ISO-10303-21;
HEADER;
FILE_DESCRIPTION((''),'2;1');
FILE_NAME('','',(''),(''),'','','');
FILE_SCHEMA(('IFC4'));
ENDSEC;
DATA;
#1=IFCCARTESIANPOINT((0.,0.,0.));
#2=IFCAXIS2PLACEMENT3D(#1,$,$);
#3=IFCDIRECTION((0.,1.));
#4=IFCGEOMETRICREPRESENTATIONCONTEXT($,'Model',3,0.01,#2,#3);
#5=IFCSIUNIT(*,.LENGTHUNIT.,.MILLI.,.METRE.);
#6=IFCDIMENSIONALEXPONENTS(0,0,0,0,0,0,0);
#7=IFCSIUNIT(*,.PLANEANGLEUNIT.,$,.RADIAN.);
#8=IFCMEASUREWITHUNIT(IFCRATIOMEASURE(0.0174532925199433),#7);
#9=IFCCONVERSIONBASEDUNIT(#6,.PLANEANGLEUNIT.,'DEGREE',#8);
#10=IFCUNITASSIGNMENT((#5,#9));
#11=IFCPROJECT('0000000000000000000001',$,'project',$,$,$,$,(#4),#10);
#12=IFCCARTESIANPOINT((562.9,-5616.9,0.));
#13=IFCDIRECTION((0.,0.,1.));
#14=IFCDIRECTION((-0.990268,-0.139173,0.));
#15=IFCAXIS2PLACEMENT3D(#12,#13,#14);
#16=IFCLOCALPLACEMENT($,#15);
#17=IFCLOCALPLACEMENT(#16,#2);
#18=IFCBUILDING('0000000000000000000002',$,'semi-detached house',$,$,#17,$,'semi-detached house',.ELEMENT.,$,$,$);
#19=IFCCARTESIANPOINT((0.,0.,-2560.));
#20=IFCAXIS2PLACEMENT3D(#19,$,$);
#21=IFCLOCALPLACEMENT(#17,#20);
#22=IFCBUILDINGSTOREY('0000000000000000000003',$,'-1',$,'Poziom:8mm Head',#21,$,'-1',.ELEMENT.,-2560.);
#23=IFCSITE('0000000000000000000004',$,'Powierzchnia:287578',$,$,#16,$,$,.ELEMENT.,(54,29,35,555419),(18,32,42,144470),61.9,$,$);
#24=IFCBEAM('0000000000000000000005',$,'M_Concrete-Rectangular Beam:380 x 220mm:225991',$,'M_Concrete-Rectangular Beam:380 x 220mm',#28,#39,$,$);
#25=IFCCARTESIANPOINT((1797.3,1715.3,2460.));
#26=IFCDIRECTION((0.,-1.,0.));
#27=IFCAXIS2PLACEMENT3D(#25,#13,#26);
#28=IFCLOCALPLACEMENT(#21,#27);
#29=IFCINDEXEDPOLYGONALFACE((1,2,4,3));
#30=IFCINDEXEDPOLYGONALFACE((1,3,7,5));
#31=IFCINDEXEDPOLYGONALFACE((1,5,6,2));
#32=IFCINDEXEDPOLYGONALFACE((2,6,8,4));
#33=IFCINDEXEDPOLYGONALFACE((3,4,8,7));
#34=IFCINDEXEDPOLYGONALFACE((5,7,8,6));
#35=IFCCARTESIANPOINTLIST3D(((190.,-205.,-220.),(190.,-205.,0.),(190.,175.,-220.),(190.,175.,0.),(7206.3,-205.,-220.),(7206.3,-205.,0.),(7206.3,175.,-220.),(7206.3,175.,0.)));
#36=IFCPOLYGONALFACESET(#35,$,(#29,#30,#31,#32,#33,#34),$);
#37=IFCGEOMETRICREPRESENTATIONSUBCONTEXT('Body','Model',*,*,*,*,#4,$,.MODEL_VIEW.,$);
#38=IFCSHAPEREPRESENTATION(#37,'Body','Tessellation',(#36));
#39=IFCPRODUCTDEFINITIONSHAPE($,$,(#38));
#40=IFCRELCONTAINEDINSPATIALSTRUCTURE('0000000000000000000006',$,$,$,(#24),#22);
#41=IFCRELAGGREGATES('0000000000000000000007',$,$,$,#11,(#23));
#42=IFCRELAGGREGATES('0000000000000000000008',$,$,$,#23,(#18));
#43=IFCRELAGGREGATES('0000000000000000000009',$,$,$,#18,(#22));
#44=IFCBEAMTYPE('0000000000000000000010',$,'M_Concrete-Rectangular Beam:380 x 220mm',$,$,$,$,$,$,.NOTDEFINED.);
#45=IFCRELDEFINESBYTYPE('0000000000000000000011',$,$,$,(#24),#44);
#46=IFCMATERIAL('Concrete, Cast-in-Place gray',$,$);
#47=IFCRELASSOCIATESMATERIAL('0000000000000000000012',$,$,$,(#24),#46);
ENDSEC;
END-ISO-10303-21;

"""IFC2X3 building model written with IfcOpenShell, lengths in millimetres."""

from ifc_helpers import new_model, entity, si_unit, converted_unit, direction, frame, frame_2d, origin, place, context, subcontext, project, spatial, rectangle, extrude, material, type_object, element, save


model = new_model("IFC2X3")

# Units and contexts
model_context = context("Model", 3, precision=0.01, world=origin(), true_north=direction((0.0, 1.0)))
body_context = subcontext(model_context, "Body", "Model", "MODEL_VIEW")
ifc_project = project(units=[si_unit("LENGTHUNIT", "METRE", prefix="MILLI"), converted_unit("PLANEANGLEUNIT", "DEGREE", entity("IfcRatioMeasure", 0.0174532925199433), si_unit("PLANEANGLEUNIT", "RADIAN"), dimensions=[0, 0, 0, 0, 0, 0, 0])], contexts=[model_context])

# Site, building, storey
site_placement = place(None, frame((562.9, -5616.9, 0.0), z_axis=(0.0, 0.0, 1.0), x_axis=(-0.990268, -0.139173, 0.0)))
site = spatial("IfcSite", under=ifc_project, at=site_placement, Name="Powierzchnia:287578", CompositionType="ELEMENT", RefLatitude=(54, 29, 35, 555419), RefLongitude=(18, 32, 42, 144470), RefElevation=61.9)
building_placement = place(site_placement, origin())
building = spatial("IfcBuilding", under=site, at=building_placement, Name="semi-detached house", LongName="semi-detached house", CompositionType="ELEMENT")
storey_placement = place(building_placement, frame((0.0, 0.0, -2560.0)))
storey = spatial("IfcBuildingStorey", under=building, at=storey_placement, Name="-1", ObjectType="Poziom:8mm Head", LongName="-1", CompositionType="ELEMENT", Elevation=-2560.0)

# Beam
ifc_material_1 = material(Name="Concrete, Cast-in-Place gray")
beam_type = type_object("IfcBeamType", Name="M_Concrete-Rectangular Beam:380 x 220mm", PredefinedType="NOTDEFINED")
beam_placement = place(storey_placement, frame((1797.3, 1715.3, 2460.0), z_axis=(0.0, 0.0, 1.0), x_axis=(0.0, -1.0, 0.0)))
element("IfcBeam", 1, at=beam_placement, inside=storey, type_object=beam_type, material=ifc_material_1, Name="M_Concrete-Rectangular Beam:380 x 220mm:225991", ObjectType="M_Concrete-Rectangular Beam:380 x 220mm", context=body_context, shape_type="SweptSolid", body=[
    extrude(rectangle(XDim=220.0, YDim=380.0, at=frame_2d((0.0, 0.0), x_axis=(1.0, 0.0))), frame((190.0, -15.0, -110.0), z_axis=(1.0, 0.0, 0.0), x_axis=(0.0, 0.0, -1.0)), (0.0, 0.0, 1.0), 7016.3),
])

save(model, "model.ifc")
